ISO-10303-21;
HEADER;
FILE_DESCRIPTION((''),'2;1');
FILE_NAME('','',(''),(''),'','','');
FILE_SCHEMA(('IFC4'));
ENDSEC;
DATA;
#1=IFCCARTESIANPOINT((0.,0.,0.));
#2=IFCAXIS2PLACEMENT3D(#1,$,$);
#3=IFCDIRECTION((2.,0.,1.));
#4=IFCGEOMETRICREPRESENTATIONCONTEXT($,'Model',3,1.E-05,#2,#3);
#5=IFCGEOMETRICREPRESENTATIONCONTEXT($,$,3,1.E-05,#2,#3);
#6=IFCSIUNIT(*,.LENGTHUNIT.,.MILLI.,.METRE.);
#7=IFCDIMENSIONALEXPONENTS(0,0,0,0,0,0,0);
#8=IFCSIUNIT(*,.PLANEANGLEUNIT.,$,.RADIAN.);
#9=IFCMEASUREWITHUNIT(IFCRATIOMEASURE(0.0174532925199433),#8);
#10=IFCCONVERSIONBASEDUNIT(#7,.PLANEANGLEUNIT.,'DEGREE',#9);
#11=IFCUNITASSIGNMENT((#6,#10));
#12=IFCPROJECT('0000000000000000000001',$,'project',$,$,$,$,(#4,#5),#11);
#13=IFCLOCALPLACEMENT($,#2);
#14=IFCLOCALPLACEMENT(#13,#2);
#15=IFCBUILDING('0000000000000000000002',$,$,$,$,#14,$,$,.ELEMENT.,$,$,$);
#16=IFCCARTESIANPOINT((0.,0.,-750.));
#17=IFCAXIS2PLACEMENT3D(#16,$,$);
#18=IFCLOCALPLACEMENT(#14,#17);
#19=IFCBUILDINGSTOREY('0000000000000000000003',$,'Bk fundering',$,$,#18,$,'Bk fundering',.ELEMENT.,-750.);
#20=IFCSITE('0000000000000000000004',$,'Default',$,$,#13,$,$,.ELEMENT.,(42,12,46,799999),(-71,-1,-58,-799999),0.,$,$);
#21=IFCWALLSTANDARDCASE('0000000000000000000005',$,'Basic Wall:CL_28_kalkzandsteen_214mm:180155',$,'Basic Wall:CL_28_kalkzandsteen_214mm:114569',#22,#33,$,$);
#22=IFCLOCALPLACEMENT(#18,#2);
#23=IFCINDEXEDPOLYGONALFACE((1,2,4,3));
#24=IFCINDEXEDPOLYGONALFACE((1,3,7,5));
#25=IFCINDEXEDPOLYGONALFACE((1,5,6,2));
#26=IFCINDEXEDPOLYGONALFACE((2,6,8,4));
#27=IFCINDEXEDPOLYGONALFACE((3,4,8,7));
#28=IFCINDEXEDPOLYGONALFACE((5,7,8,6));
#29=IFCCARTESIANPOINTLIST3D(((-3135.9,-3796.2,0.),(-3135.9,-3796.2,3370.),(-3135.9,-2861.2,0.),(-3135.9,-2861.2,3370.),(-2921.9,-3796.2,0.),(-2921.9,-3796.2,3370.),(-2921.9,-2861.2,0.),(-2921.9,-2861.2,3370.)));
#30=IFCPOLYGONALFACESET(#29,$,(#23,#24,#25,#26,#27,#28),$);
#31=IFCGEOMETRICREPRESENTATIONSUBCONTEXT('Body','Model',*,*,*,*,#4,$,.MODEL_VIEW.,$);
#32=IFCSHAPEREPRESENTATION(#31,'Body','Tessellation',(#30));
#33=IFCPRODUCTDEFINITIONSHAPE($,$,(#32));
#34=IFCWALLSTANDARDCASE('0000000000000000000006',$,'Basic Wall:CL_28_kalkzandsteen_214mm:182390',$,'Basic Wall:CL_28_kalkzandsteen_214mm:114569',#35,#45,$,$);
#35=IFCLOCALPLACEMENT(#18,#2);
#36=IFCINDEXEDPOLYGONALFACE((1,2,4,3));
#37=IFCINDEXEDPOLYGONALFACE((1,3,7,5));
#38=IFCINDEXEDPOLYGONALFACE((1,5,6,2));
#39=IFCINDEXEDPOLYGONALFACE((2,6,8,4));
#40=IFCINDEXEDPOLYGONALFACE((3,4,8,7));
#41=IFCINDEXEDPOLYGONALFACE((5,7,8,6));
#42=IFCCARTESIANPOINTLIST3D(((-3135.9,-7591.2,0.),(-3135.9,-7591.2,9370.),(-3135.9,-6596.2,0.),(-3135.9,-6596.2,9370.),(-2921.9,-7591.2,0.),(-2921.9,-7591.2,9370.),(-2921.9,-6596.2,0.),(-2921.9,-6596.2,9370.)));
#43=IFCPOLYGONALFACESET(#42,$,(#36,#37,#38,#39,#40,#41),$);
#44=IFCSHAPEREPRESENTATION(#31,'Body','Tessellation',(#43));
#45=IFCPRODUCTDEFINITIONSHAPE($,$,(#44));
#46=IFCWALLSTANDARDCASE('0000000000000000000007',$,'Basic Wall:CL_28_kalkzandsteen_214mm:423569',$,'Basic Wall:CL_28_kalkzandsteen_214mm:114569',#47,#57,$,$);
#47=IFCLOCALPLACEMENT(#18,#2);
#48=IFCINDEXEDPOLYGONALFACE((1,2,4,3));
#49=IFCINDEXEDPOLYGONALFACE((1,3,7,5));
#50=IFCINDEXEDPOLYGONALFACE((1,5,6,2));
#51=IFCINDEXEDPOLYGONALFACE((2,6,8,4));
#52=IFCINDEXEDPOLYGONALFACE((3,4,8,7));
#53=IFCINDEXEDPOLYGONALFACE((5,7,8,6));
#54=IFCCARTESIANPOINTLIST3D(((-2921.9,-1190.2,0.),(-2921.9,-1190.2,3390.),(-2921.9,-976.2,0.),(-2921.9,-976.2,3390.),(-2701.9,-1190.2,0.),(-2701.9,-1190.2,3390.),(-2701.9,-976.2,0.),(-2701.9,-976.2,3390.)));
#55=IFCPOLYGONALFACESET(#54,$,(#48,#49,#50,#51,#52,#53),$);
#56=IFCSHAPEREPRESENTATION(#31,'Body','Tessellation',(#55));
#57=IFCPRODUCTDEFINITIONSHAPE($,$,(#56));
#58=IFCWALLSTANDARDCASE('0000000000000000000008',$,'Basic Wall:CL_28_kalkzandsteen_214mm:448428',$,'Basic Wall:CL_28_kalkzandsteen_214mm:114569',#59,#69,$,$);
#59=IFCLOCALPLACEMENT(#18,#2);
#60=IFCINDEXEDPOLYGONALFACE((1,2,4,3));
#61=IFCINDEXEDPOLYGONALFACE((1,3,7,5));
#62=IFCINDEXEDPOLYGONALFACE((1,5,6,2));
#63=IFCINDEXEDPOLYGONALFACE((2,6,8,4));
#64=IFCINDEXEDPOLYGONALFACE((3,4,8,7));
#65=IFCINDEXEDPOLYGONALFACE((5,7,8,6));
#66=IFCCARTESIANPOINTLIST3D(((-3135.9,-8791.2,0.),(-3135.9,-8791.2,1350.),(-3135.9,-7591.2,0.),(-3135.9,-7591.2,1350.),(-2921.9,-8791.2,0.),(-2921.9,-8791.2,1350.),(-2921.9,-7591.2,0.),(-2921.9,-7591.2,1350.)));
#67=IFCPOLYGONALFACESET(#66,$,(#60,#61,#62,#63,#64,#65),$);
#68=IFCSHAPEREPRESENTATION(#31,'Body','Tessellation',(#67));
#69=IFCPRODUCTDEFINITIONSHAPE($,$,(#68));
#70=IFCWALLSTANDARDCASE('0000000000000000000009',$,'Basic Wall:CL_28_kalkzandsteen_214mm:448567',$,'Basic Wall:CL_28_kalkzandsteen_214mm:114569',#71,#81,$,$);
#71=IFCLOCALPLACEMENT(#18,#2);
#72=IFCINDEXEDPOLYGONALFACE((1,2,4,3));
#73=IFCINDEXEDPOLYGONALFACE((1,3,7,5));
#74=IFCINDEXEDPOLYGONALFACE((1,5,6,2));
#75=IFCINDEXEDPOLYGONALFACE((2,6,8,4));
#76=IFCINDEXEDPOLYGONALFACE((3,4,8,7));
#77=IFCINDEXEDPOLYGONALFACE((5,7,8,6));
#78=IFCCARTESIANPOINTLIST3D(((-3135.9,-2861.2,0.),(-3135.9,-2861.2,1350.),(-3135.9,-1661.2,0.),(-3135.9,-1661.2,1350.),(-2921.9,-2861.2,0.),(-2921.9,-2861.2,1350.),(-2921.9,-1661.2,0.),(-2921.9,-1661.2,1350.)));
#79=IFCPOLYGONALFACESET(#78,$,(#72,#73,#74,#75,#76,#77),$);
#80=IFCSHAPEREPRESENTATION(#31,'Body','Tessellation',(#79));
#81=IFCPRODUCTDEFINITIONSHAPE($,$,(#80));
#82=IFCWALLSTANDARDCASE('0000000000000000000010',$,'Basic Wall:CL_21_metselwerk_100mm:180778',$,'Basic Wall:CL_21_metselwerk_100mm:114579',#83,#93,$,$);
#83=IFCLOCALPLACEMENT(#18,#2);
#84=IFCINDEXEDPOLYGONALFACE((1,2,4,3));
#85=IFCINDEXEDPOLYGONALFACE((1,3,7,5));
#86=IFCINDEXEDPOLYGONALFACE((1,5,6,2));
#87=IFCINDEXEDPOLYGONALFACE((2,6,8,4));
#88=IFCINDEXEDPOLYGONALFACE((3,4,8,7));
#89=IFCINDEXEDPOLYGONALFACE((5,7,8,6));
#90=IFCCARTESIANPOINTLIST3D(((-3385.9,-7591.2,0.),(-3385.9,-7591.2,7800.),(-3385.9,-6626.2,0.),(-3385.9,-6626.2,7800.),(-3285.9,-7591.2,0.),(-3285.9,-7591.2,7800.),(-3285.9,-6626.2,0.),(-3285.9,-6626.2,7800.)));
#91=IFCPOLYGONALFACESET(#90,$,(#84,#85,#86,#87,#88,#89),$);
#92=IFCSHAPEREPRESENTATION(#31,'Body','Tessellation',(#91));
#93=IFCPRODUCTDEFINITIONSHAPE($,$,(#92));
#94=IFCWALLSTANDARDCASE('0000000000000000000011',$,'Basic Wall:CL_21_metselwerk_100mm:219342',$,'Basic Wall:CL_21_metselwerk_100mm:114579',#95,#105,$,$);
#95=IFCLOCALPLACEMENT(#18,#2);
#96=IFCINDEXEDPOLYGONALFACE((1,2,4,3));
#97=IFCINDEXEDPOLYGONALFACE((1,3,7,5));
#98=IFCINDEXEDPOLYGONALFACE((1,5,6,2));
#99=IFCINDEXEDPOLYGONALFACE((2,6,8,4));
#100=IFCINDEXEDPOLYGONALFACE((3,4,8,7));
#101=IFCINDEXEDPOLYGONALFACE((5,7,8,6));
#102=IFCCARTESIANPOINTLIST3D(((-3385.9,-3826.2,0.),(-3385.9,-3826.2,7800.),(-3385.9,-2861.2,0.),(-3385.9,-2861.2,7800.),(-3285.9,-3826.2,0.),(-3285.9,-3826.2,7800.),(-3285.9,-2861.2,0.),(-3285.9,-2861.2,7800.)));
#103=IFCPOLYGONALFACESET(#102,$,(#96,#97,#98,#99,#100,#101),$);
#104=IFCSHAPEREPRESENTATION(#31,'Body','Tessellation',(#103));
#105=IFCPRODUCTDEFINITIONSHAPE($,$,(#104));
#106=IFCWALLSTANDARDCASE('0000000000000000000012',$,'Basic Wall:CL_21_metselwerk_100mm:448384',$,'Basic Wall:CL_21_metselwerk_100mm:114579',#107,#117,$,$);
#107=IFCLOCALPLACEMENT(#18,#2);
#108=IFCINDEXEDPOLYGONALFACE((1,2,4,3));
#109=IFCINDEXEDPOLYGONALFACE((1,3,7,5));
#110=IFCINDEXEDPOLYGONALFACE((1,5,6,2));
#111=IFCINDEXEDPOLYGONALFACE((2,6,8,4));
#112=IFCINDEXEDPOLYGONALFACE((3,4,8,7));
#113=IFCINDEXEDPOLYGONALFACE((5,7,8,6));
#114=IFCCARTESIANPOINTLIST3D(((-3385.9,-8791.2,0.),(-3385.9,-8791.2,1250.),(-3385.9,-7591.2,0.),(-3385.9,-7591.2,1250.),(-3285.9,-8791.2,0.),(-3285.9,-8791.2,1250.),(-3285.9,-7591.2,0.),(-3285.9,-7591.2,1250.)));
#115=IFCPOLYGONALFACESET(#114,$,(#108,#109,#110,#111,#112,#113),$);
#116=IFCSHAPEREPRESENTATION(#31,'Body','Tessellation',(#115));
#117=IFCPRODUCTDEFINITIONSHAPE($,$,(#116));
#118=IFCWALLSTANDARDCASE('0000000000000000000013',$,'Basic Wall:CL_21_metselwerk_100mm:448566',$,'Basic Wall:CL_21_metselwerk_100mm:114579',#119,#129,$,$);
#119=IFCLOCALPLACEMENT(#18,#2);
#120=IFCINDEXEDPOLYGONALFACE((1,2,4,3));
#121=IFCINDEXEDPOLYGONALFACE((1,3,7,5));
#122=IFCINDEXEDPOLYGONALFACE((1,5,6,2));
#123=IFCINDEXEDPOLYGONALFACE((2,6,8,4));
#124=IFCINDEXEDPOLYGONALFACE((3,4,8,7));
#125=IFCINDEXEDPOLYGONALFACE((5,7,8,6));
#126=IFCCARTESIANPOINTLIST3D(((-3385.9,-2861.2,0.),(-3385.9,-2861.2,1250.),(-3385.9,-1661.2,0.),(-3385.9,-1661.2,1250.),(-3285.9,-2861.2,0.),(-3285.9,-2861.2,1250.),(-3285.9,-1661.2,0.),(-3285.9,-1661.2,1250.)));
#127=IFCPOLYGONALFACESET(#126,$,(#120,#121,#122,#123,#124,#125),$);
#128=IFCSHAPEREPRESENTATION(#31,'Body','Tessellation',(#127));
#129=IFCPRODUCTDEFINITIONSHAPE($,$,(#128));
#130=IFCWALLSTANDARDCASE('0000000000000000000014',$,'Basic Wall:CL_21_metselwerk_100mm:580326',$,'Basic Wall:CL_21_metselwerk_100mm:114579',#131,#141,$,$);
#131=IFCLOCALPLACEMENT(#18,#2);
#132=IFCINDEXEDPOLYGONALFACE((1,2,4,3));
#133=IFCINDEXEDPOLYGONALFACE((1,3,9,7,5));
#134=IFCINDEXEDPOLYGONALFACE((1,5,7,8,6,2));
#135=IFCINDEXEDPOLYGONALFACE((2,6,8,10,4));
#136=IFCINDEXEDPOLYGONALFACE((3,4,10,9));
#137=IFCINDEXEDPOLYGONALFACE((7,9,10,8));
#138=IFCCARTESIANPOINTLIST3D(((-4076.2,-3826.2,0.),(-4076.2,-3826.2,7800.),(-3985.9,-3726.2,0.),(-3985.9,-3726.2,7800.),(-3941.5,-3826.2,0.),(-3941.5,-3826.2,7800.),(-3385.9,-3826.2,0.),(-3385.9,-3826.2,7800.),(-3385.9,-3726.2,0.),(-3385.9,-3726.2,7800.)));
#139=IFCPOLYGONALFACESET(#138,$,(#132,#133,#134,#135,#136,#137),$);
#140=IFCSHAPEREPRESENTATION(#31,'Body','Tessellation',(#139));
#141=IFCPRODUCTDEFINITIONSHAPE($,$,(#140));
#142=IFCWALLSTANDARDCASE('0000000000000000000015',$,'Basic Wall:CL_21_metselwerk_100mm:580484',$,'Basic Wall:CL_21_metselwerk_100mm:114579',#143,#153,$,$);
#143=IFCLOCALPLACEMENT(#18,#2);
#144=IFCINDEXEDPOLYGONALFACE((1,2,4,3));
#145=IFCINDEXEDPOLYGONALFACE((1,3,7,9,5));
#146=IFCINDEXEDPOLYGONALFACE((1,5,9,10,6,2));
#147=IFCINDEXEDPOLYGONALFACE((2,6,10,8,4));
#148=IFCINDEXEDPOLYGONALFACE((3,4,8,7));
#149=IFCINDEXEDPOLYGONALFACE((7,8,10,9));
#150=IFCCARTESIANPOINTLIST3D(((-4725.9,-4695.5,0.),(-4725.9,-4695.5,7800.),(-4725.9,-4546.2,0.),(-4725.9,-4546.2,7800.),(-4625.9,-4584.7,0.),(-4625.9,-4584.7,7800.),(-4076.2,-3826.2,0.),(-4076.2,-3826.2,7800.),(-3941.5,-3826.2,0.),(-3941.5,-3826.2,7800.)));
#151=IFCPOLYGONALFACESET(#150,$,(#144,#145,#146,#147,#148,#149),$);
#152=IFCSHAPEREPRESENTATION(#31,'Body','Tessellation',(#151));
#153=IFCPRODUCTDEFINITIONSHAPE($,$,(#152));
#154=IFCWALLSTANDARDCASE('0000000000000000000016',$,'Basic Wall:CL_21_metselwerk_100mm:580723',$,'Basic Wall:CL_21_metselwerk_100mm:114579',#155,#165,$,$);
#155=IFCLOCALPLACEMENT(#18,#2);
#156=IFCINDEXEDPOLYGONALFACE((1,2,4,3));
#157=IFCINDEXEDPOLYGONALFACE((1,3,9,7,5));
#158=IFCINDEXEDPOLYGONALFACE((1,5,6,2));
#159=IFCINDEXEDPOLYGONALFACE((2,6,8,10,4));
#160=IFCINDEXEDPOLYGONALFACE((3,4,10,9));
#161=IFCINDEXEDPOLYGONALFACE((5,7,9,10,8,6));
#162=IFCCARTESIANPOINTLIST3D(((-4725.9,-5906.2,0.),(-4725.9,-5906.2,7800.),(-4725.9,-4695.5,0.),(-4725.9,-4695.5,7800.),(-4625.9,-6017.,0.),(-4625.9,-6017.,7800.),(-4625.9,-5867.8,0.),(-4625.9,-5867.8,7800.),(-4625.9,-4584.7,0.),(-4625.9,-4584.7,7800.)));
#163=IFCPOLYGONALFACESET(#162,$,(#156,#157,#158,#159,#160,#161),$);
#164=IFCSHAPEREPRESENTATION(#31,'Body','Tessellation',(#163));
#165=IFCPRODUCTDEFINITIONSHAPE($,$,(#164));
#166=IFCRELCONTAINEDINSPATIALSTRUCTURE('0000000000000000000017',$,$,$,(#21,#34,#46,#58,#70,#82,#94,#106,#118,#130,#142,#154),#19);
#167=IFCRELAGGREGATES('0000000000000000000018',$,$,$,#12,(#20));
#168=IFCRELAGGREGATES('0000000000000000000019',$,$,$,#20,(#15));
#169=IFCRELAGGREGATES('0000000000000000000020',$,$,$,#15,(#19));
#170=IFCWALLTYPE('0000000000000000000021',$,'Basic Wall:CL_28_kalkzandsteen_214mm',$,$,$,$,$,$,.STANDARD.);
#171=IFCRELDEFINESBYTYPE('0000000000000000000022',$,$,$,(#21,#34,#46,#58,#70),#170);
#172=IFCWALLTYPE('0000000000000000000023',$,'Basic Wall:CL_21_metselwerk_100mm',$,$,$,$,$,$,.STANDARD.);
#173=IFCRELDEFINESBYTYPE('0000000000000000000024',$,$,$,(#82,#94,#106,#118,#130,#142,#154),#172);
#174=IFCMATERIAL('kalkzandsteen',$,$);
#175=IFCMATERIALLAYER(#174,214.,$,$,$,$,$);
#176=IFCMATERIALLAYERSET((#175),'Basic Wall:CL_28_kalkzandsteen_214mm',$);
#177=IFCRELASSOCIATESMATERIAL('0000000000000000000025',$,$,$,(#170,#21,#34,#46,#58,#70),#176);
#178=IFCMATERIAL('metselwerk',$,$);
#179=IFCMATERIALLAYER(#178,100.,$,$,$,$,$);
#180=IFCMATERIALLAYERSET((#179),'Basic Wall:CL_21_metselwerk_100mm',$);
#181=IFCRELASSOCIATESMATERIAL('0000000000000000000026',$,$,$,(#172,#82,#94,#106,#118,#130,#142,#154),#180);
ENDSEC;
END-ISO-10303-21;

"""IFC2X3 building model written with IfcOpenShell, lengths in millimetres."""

from ifc_helpers import new_model, entity, si_unit, converted_unit, direction, frame, frame_2d, origin, place, context, subcontext, project, spatial, polyline, rectangle, outline, extrude, clip, bounded_halfspace, material, layer, layer_set, layer_usage, type_object, element, save


model = new_model("IFC2X3")

# Units and contexts
model_context = context("Model", 3, precision=1e-05, world=origin(), true_north=direction((2.0, 0.0, 1.0)))
context_of_model = context(None, 3, precision=1e-05, world=origin(), true_north=direction((2.0, 0.0, 1.0)))
body_context = subcontext(model_context, "Body", "Model", "MODEL_VIEW")
ifc_project = project(units=[si_unit("LENGTHUNIT", "METRE", prefix="MILLI"), converted_unit("PLANEANGLEUNIT", "DEGREE", entity("IfcRatioMeasure", 0.0174532925199433), si_unit("PLANEANGLEUNIT", "RADIAN"), dimensions=[0, 0, 0, 0, 0, 0, 0])], contexts=[model_context, context_of_model])

# Site, building, storey
site_placement = place(None, origin())
site = spatial("IfcSite", under=ifc_project, at=site_placement, Name="Default", CompositionType="ELEMENT", RefLatitude=(42, 12, 46, 799999), RefLongitude=(-71, -1, -58, -799999), RefElevation=0.0)
building_placement = place(site_placement, origin())
building = spatial("IfcBuilding", under=site, at=building_placement, CompositionType="ELEMENT")
storey_placement = place(building_placement, frame((0.0, 0.0, -750.0)))
storey = spatial("IfcBuildingStorey", under=building, at=storey_placement, Name="Bk fundering", LongName="Bk fundering", CompositionType="ELEMENT", Elevation=-750.0)

# Walls
ifc_material_1 = material(Name="kalkzandsteen")
ifc_layer_1 = layer(ifc_material_1, 214.0)
ifc_layer_set_1 = layer_set([ifc_layer_1], Name="Basic Wall:CL_28_kalkzandsteen_214mm")
ifc_layer_usage_1 = layer_usage(ifc_layer_set_1, "AXIS2", "NEGATIVE", 107.0)
wall_type_1 = type_object("IfcWallType", Name="Basic Wall:CL_28_kalkzandsteen_214mm", PredefinedType="STANDARD", material=ifc_layer_set_1)
wall_1_placement = place(storey_placement, frame((-3028.9, -2861.2, 0.0), z_axis=(0.0, 0.0, 1.0), x_axis=(0.0, -1.0, 0.0)))
element("IfcWallStandardCase", 1, at=wall_1_placement, inside=storey, type_object=wall_type_1, material=ifc_layer_usage_1, Name="Basic Wall:CL_28_kalkzandsteen_214mm:180155", ObjectType="Basic Wall:CL_28_kalkzandsteen_214mm:114569", context=body_context, shape_type="Clipping", body=[
    clip(extrude(rectangle(XDim=935.0, YDim=214.0, at=frame_2d((467.5, 0.0), x_axis=(-1.0, 0.0))), origin(), (0.0, 0.0, 1.0), 3370.0), bounded_halfspace(frame((0.0, -107.0, 3370.0), z_axis=(0.0, 0.0, -1.0), x_axis=(0.0, 1.0, 0.0)), True, frame((0.0, -107.0, 3370.0)), polyline([(0.0, 0.0), (935.0, 0.0), (935.0, 214.0), (0.0, 214.0), (0.0, 0.0)]))),
])
ifc_layer_usage_2 = layer_usage(ifc_layer_set_1, "AXIS2", "NEGATIVE", 107.0)
wall_2_placement = place(storey_placement, frame((-3028.9, -6596.2, 0.0), z_axis=(0.0, 0.0, 1.0), x_axis=(0.0, -1.0, 0.0)))
element("IfcWallStandardCase", 2, at=wall_2_placement, inside=storey, type_object=wall_type_1, material=ifc_layer_usage_2, Name="Basic Wall:CL_28_kalkzandsteen_214mm:182390", ObjectType="Basic Wall:CL_28_kalkzandsteen_214mm:114569", context=body_context, shape_type="Clipping", body=[
    clip(extrude(rectangle(XDim=995.0, YDim=214.0, at=frame_2d((497.5, 0.0), x_axis=(-1.0, 0.0))), origin(), (0.0, 0.0, 1.0), 9370.0), bounded_halfspace(frame((0.0, -107.0, 9370.0), z_axis=(0.0, 0.0, -1.0), x_axis=(0.0, 1.0, 0.0)), True, frame((0.0, -107.0, 9370.0)), polyline([(0.0, 0.0), (995.0, 0.0), (995.0, 214.0), (0.0, 214.0), (0.0, 0.0)]))),
])
ifc_layer_usage_3 = layer_usage(ifc_layer_set_1, "AXIS2", "NEGATIVE", 107.0)
wall_3_placement = place(storey_placement, frame((-2701.9, -1083.2, 0.0), z_axis=(0.0, 0.0, 1.0), x_axis=(-1.0, 0.0, 0.0)))
element("IfcWallStandardCase", 3, at=wall_3_placement, inside=storey, type_object=wall_type_1, material=ifc_layer_usage_3, Name="Basic Wall:CL_28_kalkzandsteen_214mm:423569", ObjectType="Basic Wall:CL_28_kalkzandsteen_214mm:114569", context=body_context, shape_type="SweptSolid", body=[
    extrude(rectangle(XDim=220.0, YDim=214.0, at=frame_2d((110.0, 0.0), x_axis=(-1.0, 0.0))), origin(), (0.0, 0.0, 1.0), 3390.0),
])
ifc_layer_usage_4 = layer_usage(ifc_layer_set_1, "AXIS2", "NEGATIVE", 107.0)
wall_4_placement = place(storey_placement, frame((-3028.9, -8791.2, 0.0), z_axis=(0.0, 0.0, 1.0), x_axis=(0.0, 1.0, 0.0)))
element("IfcWallStandardCase", 4, at=wall_4_placement, inside=storey, type_object=wall_type_1, material=ifc_layer_usage_4, Name="Basic Wall:CL_28_kalkzandsteen_214mm:448428", ObjectType="Basic Wall:CL_28_kalkzandsteen_214mm:114569", context=body_context, shape_type="SweptSolid", body=[
    extrude(rectangle(XDim=1200.0, YDim=214.0, at=frame_2d((600.0, 0.0), x_axis=(-1.0, 0.0))), origin(), (0.0, 0.0, 1.0), 1350.0),
])
ifc_layer_usage_5 = layer_usage(ifc_layer_set_1, "AXIS2", "NEGATIVE", 107.0)
wall_5_placement = place(storey_placement, frame((-3028.9, -2861.2, 0.0), z_axis=(0.0, 0.0, 1.0), x_axis=(0.0, 1.0, 0.0)))
element("IfcWallStandardCase", 5, at=wall_5_placement, inside=storey, type_object=wall_type_1, material=ifc_layer_usage_5, Name="Basic Wall:CL_28_kalkzandsteen_214mm:448567", ObjectType="Basic Wall:CL_28_kalkzandsteen_214mm:114569", context=body_context, shape_type="SweptSolid", body=[
    extrude(rectangle(XDim=1200.0, YDim=214.0, at=frame_2d((600.0, 0.0), x_axis=(-1.0, 0.0))), origin(), (0.0, 0.0, 1.0), 1350.0),
])
ifc_material_2 = material(Name="metselwerk")
ifc_layer_2 = layer(ifc_material_2, 100.0)
ifc_layer_set_2 = layer_set([ifc_layer_2], Name="Basic Wall:CL_21_metselwerk_100mm")
ifc_layer_usage_6 = layer_usage(ifc_layer_set_2, "AXIS2", "NEGATIVE", 50.0)
wall_type_2 = type_object("IfcWallType", Name="Basic Wall:CL_21_metselwerk_100mm", PredefinedType="STANDARD", material=ifc_layer_set_2)
wall_6_placement = place(storey_placement, frame((-3335.9, -6626.2, 0.0), z_axis=(0.0, 0.0, 1.0), x_axis=(0.0, -1.0, 0.0)))
element("IfcWallStandardCase", 6, at=wall_6_placement, inside=storey, type_object=wall_type_2, material=ifc_layer_usage_6, Name="Basic Wall:CL_21_metselwerk_100mm:180778", ObjectType="Basic Wall:CL_21_metselwerk_100mm:114579", context=body_context, shape_type="SweptSolid", body=[
    extrude(rectangle(XDim=965.0, YDim=100.0, at=frame_2d((482.5, 0.0), x_axis=(-1.0, 0.0))), origin(), (0.0, 0.0, 1.0), 7800.0),
])
ifc_layer_usage_7 = layer_usage(ifc_layer_set_2, "AXIS2", "NEGATIVE", 50.0)
wall_7_placement = place(storey_placement, frame((-3335.9, -2861.2, 0.0), z_axis=(0.0, 0.0, 1.0), x_axis=(0.0, -1.0, 0.0)))
element("IfcWallStandardCase", 7, at=wall_7_placement, inside=storey, type_object=wall_type_2, material=ifc_layer_usage_7, Name="Basic Wall:CL_21_metselwerk_100mm:219342", ObjectType="Basic Wall:CL_21_metselwerk_100mm:114579", context=body_context, shape_type="SweptSolid", body=[
    extrude(rectangle(XDim=965.0, YDim=100.0, at=frame_2d((482.5, 0.0), x_axis=(-1.0, 0.0))), origin(), (0.0, 0.0, 1.0), 7800.0),
])
ifc_layer_usage_8 = layer_usage(ifc_layer_set_2, "AXIS2", "NEGATIVE", 50.0)
wall_8_placement = place(storey_placement, frame((-3335.9, -8791.2, 0.0), z_axis=(0.0, 0.0, 1.0), x_axis=(0.0, 1.0, 0.0)))
element("IfcWallStandardCase", 8, at=wall_8_placement, inside=storey, type_object=wall_type_2, material=ifc_layer_usage_8, Name="Basic Wall:CL_21_metselwerk_100mm:448384", ObjectType="Basic Wall:CL_21_metselwerk_100mm:114579", context=body_context, shape_type="SweptSolid", body=[
    extrude(rectangle(XDim=1200.0, YDim=100.0, at=frame_2d((600.0, 0.0), x_axis=(-1.0, 0.0))), origin(), (0.0, 0.0, 1.0), 1250.0),
])
ifc_layer_usage_9 = layer_usage(ifc_layer_set_2, "AXIS2", "NEGATIVE", 50.0)
wall_9_placement = place(storey_placement, frame((-3335.9, -2861.2, 0.0), z_axis=(0.0, 0.0, 1.0), x_axis=(0.0, 1.0, 0.0)))
element("IfcWallStandardCase", 9, at=wall_9_placement, inside=storey, type_object=wall_type_2, material=ifc_layer_usage_9, Name="Basic Wall:CL_21_metselwerk_100mm:448566", ObjectType="Basic Wall:CL_21_metselwerk_100mm:114579", context=body_context, shape_type="SweptSolid", body=[
    extrude(rectangle(XDim=1200.0, YDim=100.0, at=frame_2d((600.0, 0.0), x_axis=(-1.0, 0.0))), origin(), (0.0, 0.0, 1.0), 1250.0),
])
ifc_layer_usage_10 = layer_usage(ifc_layer_set_2, "AXIS2", "NEGATIVE", 50.0)
wall_10_placement = place(storey_placement, frame((-3385.9, -3776.2, 0.0), z_axis=(0.0, 0.0, 1.0), x_axis=(-1.0, 0.0, 0.0)))
element("IfcWallStandardCase", 10, at=wall_10_placement, inside=storey, type_object=wall_type_2, material=ifc_layer_usage_10, Name="Basic Wall:CL_21_metselwerk_100mm:580326", ObjectType="Basic Wall:CL_21_metselwerk_100mm:114579", context=body_context, shape_type="SweptSolid", body=[
    extrude(outline(polyline([(600.0, -50.0), (690.3, 50.0), (555.6, 50.0), (0.0, 50.0), (0.0, -50.0), (600.0, -50.0)])), origin(), (0.0, 0.0, 1.0), 7800.0),
])
ifc_layer_usage_11 = layer_usage(ifc_layer_set_2, "AXIS2", "NEGATIVE", 50.0)
wall_11_placement = place(storey_placement, frame((-3978.6, -3792.7, 0.0), z_axis=(0.0, 0.0, 1.0), x_axis=(-0.669965, -0.742393, 0.0)))
element("IfcWallStandardCase", 11, at=wall_11_placement, inside=storey, type_object=wall_type_2, material=ifc_layer_usage_11, Name="Basic Wall:CL_21_metselwerk_100mm:580484", ObjectType="Basic Wall:CL_21_metselwerk_100mm:114579", context=body_context, shape_type="SweptSolid", body=[
    extrude(outline(polyline([(1060.1, -50.0), (1170.9, 50.0), (1021.6, 50.0), (0.0, 50.0), (90.2, -50.0), (1060.1, -50.0)])), origin(), (0.0, 0.0, 1.0), 7800.0),
])
ifc_layer_usage_12 = layer_usage(ifc_layer_set_2, "AXIS2", "NEGATIVE", 50.0)
wall_12_placement = place(storey_placement, frame((-4675.9, -4584.7, 0.0), z_axis=(0.0, 0.0, 1.0), x_axis=(0.0, -1.0, 0.0)))
element("IfcWallStandardCase", 12, at=wall_12_placement, inside=storey, type_object=wall_type_2, material=ifc_layer_usage_12, Name="Basic Wall:CL_21_metselwerk_100mm:580723", ObjectType="Basic Wall:CL_21_metselwerk_100mm:114579", context=body_context, shape_type="SweptSolid", body=[
    extrude(outline(polyline([(1321.5, -50.0), (1432.4, 50.0), (1283.1, 50.0), (0.0, 50.0), (110.8, -50.0), (1321.5, -50.0)])), origin(), (0.0, 0.0, 1.0), 7800.0),
])

save(model, "model.ifc")
